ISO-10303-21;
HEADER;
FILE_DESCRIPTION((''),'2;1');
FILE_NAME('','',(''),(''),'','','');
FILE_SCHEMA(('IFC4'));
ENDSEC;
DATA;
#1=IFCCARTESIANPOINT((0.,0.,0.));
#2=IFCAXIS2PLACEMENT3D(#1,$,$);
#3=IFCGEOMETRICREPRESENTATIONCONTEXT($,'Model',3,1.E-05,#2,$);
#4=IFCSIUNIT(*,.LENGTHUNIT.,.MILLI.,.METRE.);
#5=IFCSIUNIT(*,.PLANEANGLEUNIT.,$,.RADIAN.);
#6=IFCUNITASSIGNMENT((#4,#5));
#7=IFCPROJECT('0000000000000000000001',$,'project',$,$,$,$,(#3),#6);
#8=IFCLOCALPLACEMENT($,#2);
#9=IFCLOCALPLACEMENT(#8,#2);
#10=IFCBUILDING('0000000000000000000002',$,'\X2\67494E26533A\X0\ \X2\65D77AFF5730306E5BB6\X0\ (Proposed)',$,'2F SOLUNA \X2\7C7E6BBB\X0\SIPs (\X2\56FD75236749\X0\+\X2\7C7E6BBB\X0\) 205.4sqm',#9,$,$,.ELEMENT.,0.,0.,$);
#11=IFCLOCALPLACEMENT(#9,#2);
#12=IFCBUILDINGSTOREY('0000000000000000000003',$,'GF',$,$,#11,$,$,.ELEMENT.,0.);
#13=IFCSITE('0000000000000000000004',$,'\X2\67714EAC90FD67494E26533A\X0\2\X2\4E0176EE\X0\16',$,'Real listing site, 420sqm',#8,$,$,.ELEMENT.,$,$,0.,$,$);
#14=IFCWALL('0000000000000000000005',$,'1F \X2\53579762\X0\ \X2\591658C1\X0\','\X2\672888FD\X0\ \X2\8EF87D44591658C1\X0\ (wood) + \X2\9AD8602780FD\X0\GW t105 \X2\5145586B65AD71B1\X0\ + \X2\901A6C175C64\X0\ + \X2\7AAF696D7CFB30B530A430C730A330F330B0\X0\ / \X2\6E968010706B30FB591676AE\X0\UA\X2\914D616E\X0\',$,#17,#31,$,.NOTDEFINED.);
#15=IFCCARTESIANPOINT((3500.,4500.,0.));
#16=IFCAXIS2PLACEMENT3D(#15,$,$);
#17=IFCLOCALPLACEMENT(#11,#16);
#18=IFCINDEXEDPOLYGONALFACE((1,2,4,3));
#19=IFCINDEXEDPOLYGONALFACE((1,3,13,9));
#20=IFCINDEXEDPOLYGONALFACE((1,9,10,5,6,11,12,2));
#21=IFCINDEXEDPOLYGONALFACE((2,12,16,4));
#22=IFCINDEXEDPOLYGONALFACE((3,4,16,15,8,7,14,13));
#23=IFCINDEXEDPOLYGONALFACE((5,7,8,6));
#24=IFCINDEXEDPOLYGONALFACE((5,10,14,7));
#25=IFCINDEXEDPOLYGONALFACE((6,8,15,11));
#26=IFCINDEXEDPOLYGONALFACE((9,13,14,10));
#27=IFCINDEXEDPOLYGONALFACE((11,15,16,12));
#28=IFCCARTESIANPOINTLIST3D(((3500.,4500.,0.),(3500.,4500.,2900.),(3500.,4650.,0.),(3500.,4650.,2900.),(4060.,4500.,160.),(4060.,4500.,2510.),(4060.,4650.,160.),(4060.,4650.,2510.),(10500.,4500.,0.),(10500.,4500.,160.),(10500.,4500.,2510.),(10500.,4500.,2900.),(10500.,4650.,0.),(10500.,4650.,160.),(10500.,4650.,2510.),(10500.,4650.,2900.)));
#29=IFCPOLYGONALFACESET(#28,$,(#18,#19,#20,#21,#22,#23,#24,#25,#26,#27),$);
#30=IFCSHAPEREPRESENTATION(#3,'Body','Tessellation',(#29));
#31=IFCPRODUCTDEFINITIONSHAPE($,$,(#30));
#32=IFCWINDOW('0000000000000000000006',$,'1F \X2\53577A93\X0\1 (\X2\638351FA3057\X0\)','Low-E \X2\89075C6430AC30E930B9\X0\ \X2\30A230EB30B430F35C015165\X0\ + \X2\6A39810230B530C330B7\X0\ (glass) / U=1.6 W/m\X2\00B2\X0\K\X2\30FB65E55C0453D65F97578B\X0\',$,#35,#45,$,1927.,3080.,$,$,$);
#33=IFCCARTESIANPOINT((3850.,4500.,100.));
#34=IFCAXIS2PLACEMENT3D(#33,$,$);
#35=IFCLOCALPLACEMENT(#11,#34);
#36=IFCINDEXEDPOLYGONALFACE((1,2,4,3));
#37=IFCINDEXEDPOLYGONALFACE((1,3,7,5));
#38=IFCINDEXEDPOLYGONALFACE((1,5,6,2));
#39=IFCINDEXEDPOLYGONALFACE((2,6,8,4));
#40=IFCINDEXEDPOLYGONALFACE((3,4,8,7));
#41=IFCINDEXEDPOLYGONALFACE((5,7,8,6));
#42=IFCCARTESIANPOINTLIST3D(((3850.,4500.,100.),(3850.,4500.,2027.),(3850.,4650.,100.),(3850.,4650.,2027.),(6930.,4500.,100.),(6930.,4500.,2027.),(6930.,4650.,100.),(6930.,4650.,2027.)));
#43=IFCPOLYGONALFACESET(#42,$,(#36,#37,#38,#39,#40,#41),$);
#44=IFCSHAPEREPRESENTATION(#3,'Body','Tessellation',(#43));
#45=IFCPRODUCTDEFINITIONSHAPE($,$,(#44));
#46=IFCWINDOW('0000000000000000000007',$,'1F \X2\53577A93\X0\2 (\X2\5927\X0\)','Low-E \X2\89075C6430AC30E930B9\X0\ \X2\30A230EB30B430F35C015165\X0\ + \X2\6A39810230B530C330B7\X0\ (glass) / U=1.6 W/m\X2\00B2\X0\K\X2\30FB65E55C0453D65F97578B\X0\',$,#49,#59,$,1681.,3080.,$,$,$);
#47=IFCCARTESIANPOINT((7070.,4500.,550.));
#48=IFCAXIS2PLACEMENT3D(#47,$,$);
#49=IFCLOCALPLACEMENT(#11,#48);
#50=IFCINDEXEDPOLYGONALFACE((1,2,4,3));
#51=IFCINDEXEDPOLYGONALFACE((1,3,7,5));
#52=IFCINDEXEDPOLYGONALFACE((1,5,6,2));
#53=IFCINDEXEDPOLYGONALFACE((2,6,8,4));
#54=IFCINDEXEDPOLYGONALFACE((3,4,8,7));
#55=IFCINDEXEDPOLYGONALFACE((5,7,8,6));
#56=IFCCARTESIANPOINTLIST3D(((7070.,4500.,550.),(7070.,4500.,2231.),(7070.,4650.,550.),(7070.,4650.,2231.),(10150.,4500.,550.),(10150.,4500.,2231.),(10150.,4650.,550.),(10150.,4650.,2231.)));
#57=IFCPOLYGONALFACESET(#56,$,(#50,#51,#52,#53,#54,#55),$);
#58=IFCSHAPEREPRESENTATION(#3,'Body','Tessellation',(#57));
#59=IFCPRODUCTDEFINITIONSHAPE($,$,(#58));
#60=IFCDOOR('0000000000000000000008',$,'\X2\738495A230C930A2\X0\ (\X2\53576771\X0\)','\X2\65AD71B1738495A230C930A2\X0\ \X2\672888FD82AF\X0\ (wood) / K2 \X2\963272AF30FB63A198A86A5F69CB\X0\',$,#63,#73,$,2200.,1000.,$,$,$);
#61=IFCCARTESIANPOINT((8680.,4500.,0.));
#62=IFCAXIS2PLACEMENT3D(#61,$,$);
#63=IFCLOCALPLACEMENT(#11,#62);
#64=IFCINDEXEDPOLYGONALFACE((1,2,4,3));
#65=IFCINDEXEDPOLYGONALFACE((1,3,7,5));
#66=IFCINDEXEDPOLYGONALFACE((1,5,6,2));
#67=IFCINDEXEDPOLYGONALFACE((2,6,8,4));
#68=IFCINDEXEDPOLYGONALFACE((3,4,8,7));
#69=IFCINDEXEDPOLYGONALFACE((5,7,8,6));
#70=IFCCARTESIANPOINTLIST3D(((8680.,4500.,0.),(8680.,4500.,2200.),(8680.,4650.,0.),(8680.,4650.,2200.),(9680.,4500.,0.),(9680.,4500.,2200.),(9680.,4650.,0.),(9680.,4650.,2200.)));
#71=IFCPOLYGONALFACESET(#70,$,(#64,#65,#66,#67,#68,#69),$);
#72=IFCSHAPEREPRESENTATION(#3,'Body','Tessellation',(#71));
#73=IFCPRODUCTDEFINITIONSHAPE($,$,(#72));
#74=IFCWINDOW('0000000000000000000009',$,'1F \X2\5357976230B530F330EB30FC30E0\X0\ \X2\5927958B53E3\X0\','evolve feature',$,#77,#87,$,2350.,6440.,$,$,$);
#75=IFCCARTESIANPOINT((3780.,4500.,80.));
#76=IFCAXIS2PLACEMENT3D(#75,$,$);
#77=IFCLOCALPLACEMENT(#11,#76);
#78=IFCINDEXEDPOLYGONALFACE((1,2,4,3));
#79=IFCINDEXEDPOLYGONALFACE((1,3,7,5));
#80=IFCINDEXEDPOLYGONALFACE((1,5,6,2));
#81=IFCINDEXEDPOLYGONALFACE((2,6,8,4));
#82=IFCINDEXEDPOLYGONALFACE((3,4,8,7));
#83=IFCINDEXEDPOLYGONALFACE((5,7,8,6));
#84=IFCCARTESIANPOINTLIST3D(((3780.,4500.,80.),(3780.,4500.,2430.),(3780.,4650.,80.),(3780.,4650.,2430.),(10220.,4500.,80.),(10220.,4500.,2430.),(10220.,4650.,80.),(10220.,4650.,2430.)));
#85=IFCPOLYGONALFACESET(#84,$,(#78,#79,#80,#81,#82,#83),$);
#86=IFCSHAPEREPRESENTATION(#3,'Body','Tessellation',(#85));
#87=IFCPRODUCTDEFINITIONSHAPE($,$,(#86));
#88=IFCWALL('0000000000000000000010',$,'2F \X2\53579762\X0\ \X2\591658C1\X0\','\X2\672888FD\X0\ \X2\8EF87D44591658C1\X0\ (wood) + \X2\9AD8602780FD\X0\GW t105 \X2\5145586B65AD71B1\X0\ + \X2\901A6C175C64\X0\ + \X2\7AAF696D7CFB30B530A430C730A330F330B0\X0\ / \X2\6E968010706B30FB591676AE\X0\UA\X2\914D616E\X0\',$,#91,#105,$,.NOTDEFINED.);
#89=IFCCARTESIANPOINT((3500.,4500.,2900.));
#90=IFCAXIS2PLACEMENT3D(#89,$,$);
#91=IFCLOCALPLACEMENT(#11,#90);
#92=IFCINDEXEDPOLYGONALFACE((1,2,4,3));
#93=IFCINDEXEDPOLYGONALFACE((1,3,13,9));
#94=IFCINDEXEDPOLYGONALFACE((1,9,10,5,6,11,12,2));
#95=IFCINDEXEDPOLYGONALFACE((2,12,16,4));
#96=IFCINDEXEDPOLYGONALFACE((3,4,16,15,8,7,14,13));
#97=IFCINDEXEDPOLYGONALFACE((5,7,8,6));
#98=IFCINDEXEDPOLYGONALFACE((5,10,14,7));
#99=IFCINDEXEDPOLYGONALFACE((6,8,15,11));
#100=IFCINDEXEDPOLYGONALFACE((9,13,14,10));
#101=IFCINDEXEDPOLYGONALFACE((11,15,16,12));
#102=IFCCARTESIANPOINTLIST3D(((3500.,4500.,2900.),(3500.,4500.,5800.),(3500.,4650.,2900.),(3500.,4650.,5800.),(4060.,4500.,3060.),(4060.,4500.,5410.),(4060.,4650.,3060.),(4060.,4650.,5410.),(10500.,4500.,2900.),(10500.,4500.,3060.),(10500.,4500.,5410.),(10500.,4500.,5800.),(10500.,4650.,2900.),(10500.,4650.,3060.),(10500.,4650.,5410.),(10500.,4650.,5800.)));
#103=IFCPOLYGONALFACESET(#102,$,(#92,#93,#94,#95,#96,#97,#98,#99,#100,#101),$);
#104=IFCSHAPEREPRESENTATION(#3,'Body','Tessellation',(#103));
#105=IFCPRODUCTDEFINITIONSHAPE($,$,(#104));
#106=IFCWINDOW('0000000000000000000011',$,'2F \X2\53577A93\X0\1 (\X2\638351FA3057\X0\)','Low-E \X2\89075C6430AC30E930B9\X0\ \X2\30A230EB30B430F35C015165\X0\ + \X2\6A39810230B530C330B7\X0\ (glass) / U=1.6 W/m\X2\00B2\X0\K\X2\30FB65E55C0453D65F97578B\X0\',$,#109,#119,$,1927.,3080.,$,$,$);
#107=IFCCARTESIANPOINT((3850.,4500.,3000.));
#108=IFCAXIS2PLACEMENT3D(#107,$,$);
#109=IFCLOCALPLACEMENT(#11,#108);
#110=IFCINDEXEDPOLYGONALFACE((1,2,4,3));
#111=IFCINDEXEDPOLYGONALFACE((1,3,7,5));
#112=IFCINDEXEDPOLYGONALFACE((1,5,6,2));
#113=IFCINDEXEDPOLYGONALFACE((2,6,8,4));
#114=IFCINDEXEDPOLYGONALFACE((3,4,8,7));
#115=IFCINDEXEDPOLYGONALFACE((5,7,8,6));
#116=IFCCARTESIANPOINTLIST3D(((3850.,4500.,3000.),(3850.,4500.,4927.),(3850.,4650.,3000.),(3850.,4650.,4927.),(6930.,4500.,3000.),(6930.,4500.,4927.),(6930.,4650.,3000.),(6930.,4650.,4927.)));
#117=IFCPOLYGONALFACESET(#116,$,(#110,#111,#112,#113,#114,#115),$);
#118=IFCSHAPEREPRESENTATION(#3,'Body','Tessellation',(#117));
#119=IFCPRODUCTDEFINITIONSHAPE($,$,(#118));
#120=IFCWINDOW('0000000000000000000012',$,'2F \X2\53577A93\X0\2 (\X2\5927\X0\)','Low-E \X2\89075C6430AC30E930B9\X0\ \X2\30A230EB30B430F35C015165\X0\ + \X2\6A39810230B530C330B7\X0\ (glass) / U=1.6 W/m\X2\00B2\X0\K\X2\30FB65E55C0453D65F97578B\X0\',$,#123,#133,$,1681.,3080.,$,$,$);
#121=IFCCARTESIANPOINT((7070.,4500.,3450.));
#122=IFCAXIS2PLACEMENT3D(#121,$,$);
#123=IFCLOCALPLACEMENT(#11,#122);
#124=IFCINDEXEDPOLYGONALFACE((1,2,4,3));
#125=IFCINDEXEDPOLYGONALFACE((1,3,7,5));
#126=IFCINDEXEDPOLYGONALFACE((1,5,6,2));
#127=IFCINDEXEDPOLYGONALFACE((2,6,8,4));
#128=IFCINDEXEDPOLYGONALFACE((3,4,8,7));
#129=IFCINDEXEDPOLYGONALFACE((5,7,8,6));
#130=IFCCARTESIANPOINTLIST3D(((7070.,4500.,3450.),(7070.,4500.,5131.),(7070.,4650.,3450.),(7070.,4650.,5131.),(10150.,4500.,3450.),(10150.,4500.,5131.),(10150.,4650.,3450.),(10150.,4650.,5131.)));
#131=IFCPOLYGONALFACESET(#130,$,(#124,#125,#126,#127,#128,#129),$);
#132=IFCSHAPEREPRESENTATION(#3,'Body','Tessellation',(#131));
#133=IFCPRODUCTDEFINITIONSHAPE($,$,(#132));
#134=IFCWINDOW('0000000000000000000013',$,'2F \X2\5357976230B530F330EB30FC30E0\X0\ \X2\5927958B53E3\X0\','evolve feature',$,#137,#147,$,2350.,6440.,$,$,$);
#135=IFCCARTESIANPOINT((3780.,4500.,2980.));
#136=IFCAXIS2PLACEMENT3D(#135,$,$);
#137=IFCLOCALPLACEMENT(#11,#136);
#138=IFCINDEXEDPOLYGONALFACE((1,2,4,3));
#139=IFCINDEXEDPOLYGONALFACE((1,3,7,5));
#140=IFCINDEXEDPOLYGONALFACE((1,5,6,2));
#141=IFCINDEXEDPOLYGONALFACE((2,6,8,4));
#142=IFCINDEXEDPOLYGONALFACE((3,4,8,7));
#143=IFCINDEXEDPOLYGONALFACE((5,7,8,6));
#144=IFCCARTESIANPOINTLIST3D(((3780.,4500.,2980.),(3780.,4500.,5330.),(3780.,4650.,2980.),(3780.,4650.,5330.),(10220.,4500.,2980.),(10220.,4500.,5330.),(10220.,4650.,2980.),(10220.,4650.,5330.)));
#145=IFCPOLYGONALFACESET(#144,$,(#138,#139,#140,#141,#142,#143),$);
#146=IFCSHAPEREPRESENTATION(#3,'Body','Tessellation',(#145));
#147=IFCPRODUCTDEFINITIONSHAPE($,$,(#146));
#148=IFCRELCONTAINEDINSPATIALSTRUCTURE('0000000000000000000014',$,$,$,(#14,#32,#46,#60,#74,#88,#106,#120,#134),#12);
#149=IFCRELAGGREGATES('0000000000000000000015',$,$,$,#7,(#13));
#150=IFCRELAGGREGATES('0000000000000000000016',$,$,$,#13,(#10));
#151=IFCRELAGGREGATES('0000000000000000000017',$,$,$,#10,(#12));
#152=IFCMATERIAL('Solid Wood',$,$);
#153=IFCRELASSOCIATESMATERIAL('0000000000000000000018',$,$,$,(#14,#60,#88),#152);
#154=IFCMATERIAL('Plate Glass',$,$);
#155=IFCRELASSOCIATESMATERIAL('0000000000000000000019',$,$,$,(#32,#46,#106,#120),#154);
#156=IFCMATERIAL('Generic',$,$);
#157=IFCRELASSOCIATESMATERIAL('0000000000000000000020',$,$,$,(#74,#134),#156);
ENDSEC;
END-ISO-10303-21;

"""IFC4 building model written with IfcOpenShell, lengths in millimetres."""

from ifc_helpers import new_model, si_unit, frame, frame_2d, origin, place, context, project, spatial, rectangle, extrude, material, element, fill, save


model = new_model("IFC4")

# Units and contexts
model_context = context("Model", 3, precision=1e-05, world=origin())
ifc_project = project(units=[si_unit("LENGTHUNIT", "METRE", prefix="MILLI"), si_unit("PLANEANGLEUNIT", "RADIAN")], contexts=[model_context])

# Site, building, storey
site_placement = place(None, origin())
site = spatial("IfcSite", under=ifc_project, at=site_placement, Name="東京都杉並区2丁目16", ObjectType="Real listing site, 420sqm", CompositionType="ELEMENT", RefElevation=0.0)
building_placement = place(site_placement, origin())
building = spatial("IfcBuilding", under=site, at=building_placement, Name="杉並区 旗竿地の家 (Proposed)", ObjectType="2F SOLUNA 籾殻SIPs (国産杉+籾殻) 205.4sqm", CompositionType="ELEMENT", ElevationOfRefHeight=0.0, ElevationOfTerrain=0.0)
storey_placement = place(building_placement, origin())
storey = spatial("IfcBuildingStorey", under=building, at=storey_placement, Name="GF", CompositionType="ELEMENT", Elevation=0.0)

# Shared definitions
ifc_material_1 = material(Name="Solid Wood")

# Wall, openings, windows, door
wall_1_placement = place(storey_placement, frame((3500.0, 4500.0, 0.0)))
wall_1 = element("IfcWall", 1, at=wall_1_placement, inside=storey, material=ifc_material_1, Name="1F 南面 外壁", Description="木製 軸組外壁 (wood) + 高性能GW t105 充填断熱 + 通気層 + 窯業系サイディング / 準耐火・外皮UA配慮", PredefinedType="NOTDEFINED", context=model_context, shape_type="SweptSolid", body=[
    extrude(rectangle(XDim=7000.0, YDim=150.0, at=frame_2d((3500.0, 75.0))), frame((3500.0, 4500.0, 0.0)), (0.0, 0.0, 1.0), 2900.0),
])
opening_1_placement = place(storey_placement, frame((3850.0, 4500.0, 100.0)))
opening_1 = element("IfcOpeningElement", 2, at=opening_1_placement, cuts=wall_1, PredefinedType="NOTDEFINED", context=model_context, shape_type="SweptSolid", body=[
    extrude(rectangle(XDim=3080.0, YDim=150.0, at=frame_2d((1540.0, 75.0))), frame((3850.0, 4500.0, 100.0)), (0.0, 0.0, 1.0), 1927.0),
])
opening_2_placement = place(storey_placement, frame((7070.0, 4500.0, 550.0)))
opening_2 = element("IfcOpeningElement", 3, at=opening_2_placement, cuts=wall_1, PredefinedType="NOTDEFINED", context=model_context, shape_type="SweptSolid", body=[
    extrude(rectangle(XDim=3080.0, YDim=150.0, at=frame_2d((1540.0, 75.0))), frame((7070.0, 4500.0, 550.0)), (0.0, 0.0, 1.0), 1681.0),
])
opening_3_placement = place(storey_placement, frame((8680.0, 4500.0, 0.0)))
opening_3 = element("IfcOpeningElement", 4, at=opening_3_placement, cuts=wall_1, PredefinedType="NOTDEFINED", context=model_context, shape_type="SweptSolid", body=[
    extrude(rectangle(XDim=1000.0, YDim=150.0, at=frame_2d((500.0, 75.0))), frame((8680.0, 4500.0, 0.0)), (0.0, 0.0, 1.0), 2200.0),
])
opening_4_placement = place(storey_placement, frame((3780.0, 4500.0, 80.0)))
opening_4 = element("IfcOpeningElement", 5, at=opening_4_placement, cuts=wall_1, PredefinedType="NOTDEFINED", context=model_context, shape_type="SweptSolid", body=[
    extrude(rectangle(XDim=6440.0, YDim=150.0, at=frame_2d((3220.0, 75.0))), frame((3780.0, 4500.0, 80.0)), (0.0, 0.0, 1.0), 2350.0),
])
ifc_material_2 = material(Name="Plate Glass")
window_1_placement = place(storey_placement, frame((3850.0, 4500.0, 100.0)))
window_1 = element("IfcWindow", 6, at=window_1_placement, inside=storey, material=ifc_material_2, Name="1F 南窓1 (掃出し)", Description="Low-E 複層ガラス アルゴン封入 + 樹脂サッシ (glass) / U=1.6 W/m²K・日射取得型", OverallHeight=1927.0, OverallWidth=3080.0, context=model_context, shape_type="SweptSolid", body=[
    extrude(rectangle(XDim=3080.0, YDim=150.0, at=frame_2d((1540.0, 75.0))), frame((3850.0, 4500.0, 100.0)), (0.0, 0.0, 1.0), 1927.0),
])
fill(opening_1, window_1)
window_2_placement = place(storey_placement, frame((7070.0, 4500.0, 550.0)))
window_2 = element("IfcWindow", 7, at=window_2_placement, inside=storey, material=ifc_material_2, Name="1F 南窓2 (大)", Description="Low-E 複層ガラス アルゴン封入 + 樹脂サッシ (glass) / U=1.6 W/m²K・日射取得型", OverallHeight=1681.0, OverallWidth=3080.0, context=model_context, shape_type="SweptSolid", body=[
    extrude(rectangle(XDim=3080.0, YDim=150.0, at=frame_2d((1540.0, 75.0))), frame((7070.0, 4500.0, 550.0)), (0.0, 0.0, 1.0), 1681.0),
])
fill(opening_2, window_2)
door_placement = place(storey_placement, frame((8680.0, 4500.0, 0.0)))
door = element("IfcDoor", 8, at=door_placement, inside=storey, material=ifc_material_1, Name="玄関ドア (南東)", Description="断熱玄関ドア 木製芯 (wood) / K2 防犯・採風機構", OverallHeight=2200.0, OverallWidth=1000.0, context=model_context, shape_type="SweptSolid", body=[
    extrude(rectangle(XDim=1000.0, YDim=150.0, at=frame_2d((500.0, 75.0))), frame((8680.0, 4500.0, 0.0)), (0.0, 0.0, 1.0), 2200.0),
])
fill(opening_3, door)
ifc_material_3 = material(Name="Generic")
window_3_placement = place(storey_placement, frame((3780.0, 4500.0, 80.0)))
window_3 = element("IfcWindow", 9, at=window_3_placement, inside=storey, material=ifc_material_3, Name="1F 南面サンルーム 大開口", Description="evolve feature", OverallHeight=2350.0, OverallWidth=6440.0, context=model_context, shape_type="SweptSolid", body=[
    extrude(rectangle(XDim=6440.0, YDim=150.0, at=frame_2d((3220.0, 75.0))), frame((3780.0, 4500.0, 80.0)), (0.0, 0.0, 1.0), 2350.0),
])
fill(opening_4, window_3)

# Wall, openings, windows
wall_2_placement = place(storey_placement, frame((3500.0, 4500.0, 2900.0)))
wall_2 = element("IfcWall", 10, at=wall_2_placement, inside=storey, material=ifc_material_1, Name="2F 南面 外壁", Description="木製 軸組外壁 (wood) + 高性能GW t105 充填断熱 + 通気層 + 窯業系サイディング / 準耐火・外皮UA配慮", PredefinedType="NOTDEFINED", context=model_context, shape_type="SweptSolid", body=[
    extrude(rectangle(XDim=7000.0, YDim=150.0, at=frame_2d((3500.0, 75.0))), frame((3500.0, 4500.0, 2900.0)), (0.0, 0.0, 1.0), 2900.0),
])
opening_5_placement = place(storey_placement, frame((3850.0, 4500.0, 3000.0)))
opening_5 = element("IfcOpeningElement", 11, at=opening_5_placement, cuts=wall_2, PredefinedType="NOTDEFINED", context=model_context, shape_type="SweptSolid", body=[
    extrude(rectangle(XDim=3080.0, YDim=150.0, at=frame_2d((1540.0, 75.0))), frame((3850.0, 4500.0, 3000.0)), (0.0, 0.0, 1.0), 1927.0),
])
opening_6_placement = place(storey_placement, frame((7070.0, 4500.0, 3450.0)))
opening_6 = element("IfcOpeningElement", 12, at=opening_6_placement, cuts=wall_2, PredefinedType="NOTDEFINED", context=model_context, shape_type="SweptSolid", body=[
    extrude(rectangle(XDim=3080.0, YDim=150.0, at=frame_2d((1540.0, 75.0))), frame((7070.0, 4500.0, 3450.0)), (0.0, 0.0, 1.0), 1681.0),
])
opening_7_placement = place(storey_placement, frame((3780.0, 4500.0, 2980.0)))
opening_7 = element("IfcOpeningElement", 13, at=opening_7_placement, cuts=wall_2, PredefinedType="NOTDEFINED", context=model_context, shape_type="SweptSolid", body=[
    extrude(rectangle(XDim=6440.0, YDim=150.0, at=frame_2d((3220.0, 75.0))), frame((3780.0, 4500.0, 2980.0)), (0.0, 0.0, 1.0), 2350.0),
])
window_4_placement = place(storey_placement, frame((3850.0, 4500.0, 3000.0)))
window_4 = element("IfcWindow", 14, at=window_4_placement, inside=storey, material=ifc_material_2, Name="2F 南窓1 (掃出し)", Description="Low-E 複層ガラス アルゴン封入 + 樹脂サッシ (glass) / U=1.6 W/m²K・日射取得型", OverallHeight=1927.0, OverallWidth=3080.0, context=model_context, shape_type="SweptSolid", body=[
    extrude(rectangle(XDim=3080.0, YDim=150.0, at=frame_2d((1540.0, 75.0))), frame((3850.0, 4500.0, 3000.0)), (0.0, 0.0, 1.0), 1927.0),
])
fill(opening_5, window_4)
window_5_placement = place(storey_placement, frame((7070.0, 4500.0, 3450.0)))
window_5 = element("IfcWindow", 15, at=window_5_placement, inside=storey, material=ifc_material_2, Name="2F 南窓2 (大)", Description="Low-E 複層ガラス アルゴン封入 + 樹脂サッシ (glass) / U=1.6 W/m²K・日射取得型", OverallHeight=1681.0, OverallWidth=3080.0, context=model_context, shape_type="SweptSolid", body=[
    extrude(rectangle(XDim=3080.0, YDim=150.0, at=frame_2d((1540.0, 75.0))), frame((7070.0, 4500.0, 3450.0)), (0.0, 0.0, 1.0), 1681.0),
])
fill(opening_6, window_5)
window_6_placement = place(storey_placement, frame((3780.0, 4500.0, 2980.0)))
window_6 = element("IfcWindow", 16, at=window_6_placement, inside=storey, material=ifc_material_3, Name="2F 南面サンルーム 大開口", Description="evolve feature", OverallHeight=2350.0, OverallWidth=6440.0, context=model_context, shape_type="SweptSolid", body=[
    extrude(rectangle(XDim=6440.0, YDim=150.0, at=frame_2d((3220.0, 75.0))), frame((3780.0, 4500.0, 2980.0)), (0.0, 0.0, 1.0), 2350.0),
])
fill(opening_7, window_6)

save(model, "model.ifc")
